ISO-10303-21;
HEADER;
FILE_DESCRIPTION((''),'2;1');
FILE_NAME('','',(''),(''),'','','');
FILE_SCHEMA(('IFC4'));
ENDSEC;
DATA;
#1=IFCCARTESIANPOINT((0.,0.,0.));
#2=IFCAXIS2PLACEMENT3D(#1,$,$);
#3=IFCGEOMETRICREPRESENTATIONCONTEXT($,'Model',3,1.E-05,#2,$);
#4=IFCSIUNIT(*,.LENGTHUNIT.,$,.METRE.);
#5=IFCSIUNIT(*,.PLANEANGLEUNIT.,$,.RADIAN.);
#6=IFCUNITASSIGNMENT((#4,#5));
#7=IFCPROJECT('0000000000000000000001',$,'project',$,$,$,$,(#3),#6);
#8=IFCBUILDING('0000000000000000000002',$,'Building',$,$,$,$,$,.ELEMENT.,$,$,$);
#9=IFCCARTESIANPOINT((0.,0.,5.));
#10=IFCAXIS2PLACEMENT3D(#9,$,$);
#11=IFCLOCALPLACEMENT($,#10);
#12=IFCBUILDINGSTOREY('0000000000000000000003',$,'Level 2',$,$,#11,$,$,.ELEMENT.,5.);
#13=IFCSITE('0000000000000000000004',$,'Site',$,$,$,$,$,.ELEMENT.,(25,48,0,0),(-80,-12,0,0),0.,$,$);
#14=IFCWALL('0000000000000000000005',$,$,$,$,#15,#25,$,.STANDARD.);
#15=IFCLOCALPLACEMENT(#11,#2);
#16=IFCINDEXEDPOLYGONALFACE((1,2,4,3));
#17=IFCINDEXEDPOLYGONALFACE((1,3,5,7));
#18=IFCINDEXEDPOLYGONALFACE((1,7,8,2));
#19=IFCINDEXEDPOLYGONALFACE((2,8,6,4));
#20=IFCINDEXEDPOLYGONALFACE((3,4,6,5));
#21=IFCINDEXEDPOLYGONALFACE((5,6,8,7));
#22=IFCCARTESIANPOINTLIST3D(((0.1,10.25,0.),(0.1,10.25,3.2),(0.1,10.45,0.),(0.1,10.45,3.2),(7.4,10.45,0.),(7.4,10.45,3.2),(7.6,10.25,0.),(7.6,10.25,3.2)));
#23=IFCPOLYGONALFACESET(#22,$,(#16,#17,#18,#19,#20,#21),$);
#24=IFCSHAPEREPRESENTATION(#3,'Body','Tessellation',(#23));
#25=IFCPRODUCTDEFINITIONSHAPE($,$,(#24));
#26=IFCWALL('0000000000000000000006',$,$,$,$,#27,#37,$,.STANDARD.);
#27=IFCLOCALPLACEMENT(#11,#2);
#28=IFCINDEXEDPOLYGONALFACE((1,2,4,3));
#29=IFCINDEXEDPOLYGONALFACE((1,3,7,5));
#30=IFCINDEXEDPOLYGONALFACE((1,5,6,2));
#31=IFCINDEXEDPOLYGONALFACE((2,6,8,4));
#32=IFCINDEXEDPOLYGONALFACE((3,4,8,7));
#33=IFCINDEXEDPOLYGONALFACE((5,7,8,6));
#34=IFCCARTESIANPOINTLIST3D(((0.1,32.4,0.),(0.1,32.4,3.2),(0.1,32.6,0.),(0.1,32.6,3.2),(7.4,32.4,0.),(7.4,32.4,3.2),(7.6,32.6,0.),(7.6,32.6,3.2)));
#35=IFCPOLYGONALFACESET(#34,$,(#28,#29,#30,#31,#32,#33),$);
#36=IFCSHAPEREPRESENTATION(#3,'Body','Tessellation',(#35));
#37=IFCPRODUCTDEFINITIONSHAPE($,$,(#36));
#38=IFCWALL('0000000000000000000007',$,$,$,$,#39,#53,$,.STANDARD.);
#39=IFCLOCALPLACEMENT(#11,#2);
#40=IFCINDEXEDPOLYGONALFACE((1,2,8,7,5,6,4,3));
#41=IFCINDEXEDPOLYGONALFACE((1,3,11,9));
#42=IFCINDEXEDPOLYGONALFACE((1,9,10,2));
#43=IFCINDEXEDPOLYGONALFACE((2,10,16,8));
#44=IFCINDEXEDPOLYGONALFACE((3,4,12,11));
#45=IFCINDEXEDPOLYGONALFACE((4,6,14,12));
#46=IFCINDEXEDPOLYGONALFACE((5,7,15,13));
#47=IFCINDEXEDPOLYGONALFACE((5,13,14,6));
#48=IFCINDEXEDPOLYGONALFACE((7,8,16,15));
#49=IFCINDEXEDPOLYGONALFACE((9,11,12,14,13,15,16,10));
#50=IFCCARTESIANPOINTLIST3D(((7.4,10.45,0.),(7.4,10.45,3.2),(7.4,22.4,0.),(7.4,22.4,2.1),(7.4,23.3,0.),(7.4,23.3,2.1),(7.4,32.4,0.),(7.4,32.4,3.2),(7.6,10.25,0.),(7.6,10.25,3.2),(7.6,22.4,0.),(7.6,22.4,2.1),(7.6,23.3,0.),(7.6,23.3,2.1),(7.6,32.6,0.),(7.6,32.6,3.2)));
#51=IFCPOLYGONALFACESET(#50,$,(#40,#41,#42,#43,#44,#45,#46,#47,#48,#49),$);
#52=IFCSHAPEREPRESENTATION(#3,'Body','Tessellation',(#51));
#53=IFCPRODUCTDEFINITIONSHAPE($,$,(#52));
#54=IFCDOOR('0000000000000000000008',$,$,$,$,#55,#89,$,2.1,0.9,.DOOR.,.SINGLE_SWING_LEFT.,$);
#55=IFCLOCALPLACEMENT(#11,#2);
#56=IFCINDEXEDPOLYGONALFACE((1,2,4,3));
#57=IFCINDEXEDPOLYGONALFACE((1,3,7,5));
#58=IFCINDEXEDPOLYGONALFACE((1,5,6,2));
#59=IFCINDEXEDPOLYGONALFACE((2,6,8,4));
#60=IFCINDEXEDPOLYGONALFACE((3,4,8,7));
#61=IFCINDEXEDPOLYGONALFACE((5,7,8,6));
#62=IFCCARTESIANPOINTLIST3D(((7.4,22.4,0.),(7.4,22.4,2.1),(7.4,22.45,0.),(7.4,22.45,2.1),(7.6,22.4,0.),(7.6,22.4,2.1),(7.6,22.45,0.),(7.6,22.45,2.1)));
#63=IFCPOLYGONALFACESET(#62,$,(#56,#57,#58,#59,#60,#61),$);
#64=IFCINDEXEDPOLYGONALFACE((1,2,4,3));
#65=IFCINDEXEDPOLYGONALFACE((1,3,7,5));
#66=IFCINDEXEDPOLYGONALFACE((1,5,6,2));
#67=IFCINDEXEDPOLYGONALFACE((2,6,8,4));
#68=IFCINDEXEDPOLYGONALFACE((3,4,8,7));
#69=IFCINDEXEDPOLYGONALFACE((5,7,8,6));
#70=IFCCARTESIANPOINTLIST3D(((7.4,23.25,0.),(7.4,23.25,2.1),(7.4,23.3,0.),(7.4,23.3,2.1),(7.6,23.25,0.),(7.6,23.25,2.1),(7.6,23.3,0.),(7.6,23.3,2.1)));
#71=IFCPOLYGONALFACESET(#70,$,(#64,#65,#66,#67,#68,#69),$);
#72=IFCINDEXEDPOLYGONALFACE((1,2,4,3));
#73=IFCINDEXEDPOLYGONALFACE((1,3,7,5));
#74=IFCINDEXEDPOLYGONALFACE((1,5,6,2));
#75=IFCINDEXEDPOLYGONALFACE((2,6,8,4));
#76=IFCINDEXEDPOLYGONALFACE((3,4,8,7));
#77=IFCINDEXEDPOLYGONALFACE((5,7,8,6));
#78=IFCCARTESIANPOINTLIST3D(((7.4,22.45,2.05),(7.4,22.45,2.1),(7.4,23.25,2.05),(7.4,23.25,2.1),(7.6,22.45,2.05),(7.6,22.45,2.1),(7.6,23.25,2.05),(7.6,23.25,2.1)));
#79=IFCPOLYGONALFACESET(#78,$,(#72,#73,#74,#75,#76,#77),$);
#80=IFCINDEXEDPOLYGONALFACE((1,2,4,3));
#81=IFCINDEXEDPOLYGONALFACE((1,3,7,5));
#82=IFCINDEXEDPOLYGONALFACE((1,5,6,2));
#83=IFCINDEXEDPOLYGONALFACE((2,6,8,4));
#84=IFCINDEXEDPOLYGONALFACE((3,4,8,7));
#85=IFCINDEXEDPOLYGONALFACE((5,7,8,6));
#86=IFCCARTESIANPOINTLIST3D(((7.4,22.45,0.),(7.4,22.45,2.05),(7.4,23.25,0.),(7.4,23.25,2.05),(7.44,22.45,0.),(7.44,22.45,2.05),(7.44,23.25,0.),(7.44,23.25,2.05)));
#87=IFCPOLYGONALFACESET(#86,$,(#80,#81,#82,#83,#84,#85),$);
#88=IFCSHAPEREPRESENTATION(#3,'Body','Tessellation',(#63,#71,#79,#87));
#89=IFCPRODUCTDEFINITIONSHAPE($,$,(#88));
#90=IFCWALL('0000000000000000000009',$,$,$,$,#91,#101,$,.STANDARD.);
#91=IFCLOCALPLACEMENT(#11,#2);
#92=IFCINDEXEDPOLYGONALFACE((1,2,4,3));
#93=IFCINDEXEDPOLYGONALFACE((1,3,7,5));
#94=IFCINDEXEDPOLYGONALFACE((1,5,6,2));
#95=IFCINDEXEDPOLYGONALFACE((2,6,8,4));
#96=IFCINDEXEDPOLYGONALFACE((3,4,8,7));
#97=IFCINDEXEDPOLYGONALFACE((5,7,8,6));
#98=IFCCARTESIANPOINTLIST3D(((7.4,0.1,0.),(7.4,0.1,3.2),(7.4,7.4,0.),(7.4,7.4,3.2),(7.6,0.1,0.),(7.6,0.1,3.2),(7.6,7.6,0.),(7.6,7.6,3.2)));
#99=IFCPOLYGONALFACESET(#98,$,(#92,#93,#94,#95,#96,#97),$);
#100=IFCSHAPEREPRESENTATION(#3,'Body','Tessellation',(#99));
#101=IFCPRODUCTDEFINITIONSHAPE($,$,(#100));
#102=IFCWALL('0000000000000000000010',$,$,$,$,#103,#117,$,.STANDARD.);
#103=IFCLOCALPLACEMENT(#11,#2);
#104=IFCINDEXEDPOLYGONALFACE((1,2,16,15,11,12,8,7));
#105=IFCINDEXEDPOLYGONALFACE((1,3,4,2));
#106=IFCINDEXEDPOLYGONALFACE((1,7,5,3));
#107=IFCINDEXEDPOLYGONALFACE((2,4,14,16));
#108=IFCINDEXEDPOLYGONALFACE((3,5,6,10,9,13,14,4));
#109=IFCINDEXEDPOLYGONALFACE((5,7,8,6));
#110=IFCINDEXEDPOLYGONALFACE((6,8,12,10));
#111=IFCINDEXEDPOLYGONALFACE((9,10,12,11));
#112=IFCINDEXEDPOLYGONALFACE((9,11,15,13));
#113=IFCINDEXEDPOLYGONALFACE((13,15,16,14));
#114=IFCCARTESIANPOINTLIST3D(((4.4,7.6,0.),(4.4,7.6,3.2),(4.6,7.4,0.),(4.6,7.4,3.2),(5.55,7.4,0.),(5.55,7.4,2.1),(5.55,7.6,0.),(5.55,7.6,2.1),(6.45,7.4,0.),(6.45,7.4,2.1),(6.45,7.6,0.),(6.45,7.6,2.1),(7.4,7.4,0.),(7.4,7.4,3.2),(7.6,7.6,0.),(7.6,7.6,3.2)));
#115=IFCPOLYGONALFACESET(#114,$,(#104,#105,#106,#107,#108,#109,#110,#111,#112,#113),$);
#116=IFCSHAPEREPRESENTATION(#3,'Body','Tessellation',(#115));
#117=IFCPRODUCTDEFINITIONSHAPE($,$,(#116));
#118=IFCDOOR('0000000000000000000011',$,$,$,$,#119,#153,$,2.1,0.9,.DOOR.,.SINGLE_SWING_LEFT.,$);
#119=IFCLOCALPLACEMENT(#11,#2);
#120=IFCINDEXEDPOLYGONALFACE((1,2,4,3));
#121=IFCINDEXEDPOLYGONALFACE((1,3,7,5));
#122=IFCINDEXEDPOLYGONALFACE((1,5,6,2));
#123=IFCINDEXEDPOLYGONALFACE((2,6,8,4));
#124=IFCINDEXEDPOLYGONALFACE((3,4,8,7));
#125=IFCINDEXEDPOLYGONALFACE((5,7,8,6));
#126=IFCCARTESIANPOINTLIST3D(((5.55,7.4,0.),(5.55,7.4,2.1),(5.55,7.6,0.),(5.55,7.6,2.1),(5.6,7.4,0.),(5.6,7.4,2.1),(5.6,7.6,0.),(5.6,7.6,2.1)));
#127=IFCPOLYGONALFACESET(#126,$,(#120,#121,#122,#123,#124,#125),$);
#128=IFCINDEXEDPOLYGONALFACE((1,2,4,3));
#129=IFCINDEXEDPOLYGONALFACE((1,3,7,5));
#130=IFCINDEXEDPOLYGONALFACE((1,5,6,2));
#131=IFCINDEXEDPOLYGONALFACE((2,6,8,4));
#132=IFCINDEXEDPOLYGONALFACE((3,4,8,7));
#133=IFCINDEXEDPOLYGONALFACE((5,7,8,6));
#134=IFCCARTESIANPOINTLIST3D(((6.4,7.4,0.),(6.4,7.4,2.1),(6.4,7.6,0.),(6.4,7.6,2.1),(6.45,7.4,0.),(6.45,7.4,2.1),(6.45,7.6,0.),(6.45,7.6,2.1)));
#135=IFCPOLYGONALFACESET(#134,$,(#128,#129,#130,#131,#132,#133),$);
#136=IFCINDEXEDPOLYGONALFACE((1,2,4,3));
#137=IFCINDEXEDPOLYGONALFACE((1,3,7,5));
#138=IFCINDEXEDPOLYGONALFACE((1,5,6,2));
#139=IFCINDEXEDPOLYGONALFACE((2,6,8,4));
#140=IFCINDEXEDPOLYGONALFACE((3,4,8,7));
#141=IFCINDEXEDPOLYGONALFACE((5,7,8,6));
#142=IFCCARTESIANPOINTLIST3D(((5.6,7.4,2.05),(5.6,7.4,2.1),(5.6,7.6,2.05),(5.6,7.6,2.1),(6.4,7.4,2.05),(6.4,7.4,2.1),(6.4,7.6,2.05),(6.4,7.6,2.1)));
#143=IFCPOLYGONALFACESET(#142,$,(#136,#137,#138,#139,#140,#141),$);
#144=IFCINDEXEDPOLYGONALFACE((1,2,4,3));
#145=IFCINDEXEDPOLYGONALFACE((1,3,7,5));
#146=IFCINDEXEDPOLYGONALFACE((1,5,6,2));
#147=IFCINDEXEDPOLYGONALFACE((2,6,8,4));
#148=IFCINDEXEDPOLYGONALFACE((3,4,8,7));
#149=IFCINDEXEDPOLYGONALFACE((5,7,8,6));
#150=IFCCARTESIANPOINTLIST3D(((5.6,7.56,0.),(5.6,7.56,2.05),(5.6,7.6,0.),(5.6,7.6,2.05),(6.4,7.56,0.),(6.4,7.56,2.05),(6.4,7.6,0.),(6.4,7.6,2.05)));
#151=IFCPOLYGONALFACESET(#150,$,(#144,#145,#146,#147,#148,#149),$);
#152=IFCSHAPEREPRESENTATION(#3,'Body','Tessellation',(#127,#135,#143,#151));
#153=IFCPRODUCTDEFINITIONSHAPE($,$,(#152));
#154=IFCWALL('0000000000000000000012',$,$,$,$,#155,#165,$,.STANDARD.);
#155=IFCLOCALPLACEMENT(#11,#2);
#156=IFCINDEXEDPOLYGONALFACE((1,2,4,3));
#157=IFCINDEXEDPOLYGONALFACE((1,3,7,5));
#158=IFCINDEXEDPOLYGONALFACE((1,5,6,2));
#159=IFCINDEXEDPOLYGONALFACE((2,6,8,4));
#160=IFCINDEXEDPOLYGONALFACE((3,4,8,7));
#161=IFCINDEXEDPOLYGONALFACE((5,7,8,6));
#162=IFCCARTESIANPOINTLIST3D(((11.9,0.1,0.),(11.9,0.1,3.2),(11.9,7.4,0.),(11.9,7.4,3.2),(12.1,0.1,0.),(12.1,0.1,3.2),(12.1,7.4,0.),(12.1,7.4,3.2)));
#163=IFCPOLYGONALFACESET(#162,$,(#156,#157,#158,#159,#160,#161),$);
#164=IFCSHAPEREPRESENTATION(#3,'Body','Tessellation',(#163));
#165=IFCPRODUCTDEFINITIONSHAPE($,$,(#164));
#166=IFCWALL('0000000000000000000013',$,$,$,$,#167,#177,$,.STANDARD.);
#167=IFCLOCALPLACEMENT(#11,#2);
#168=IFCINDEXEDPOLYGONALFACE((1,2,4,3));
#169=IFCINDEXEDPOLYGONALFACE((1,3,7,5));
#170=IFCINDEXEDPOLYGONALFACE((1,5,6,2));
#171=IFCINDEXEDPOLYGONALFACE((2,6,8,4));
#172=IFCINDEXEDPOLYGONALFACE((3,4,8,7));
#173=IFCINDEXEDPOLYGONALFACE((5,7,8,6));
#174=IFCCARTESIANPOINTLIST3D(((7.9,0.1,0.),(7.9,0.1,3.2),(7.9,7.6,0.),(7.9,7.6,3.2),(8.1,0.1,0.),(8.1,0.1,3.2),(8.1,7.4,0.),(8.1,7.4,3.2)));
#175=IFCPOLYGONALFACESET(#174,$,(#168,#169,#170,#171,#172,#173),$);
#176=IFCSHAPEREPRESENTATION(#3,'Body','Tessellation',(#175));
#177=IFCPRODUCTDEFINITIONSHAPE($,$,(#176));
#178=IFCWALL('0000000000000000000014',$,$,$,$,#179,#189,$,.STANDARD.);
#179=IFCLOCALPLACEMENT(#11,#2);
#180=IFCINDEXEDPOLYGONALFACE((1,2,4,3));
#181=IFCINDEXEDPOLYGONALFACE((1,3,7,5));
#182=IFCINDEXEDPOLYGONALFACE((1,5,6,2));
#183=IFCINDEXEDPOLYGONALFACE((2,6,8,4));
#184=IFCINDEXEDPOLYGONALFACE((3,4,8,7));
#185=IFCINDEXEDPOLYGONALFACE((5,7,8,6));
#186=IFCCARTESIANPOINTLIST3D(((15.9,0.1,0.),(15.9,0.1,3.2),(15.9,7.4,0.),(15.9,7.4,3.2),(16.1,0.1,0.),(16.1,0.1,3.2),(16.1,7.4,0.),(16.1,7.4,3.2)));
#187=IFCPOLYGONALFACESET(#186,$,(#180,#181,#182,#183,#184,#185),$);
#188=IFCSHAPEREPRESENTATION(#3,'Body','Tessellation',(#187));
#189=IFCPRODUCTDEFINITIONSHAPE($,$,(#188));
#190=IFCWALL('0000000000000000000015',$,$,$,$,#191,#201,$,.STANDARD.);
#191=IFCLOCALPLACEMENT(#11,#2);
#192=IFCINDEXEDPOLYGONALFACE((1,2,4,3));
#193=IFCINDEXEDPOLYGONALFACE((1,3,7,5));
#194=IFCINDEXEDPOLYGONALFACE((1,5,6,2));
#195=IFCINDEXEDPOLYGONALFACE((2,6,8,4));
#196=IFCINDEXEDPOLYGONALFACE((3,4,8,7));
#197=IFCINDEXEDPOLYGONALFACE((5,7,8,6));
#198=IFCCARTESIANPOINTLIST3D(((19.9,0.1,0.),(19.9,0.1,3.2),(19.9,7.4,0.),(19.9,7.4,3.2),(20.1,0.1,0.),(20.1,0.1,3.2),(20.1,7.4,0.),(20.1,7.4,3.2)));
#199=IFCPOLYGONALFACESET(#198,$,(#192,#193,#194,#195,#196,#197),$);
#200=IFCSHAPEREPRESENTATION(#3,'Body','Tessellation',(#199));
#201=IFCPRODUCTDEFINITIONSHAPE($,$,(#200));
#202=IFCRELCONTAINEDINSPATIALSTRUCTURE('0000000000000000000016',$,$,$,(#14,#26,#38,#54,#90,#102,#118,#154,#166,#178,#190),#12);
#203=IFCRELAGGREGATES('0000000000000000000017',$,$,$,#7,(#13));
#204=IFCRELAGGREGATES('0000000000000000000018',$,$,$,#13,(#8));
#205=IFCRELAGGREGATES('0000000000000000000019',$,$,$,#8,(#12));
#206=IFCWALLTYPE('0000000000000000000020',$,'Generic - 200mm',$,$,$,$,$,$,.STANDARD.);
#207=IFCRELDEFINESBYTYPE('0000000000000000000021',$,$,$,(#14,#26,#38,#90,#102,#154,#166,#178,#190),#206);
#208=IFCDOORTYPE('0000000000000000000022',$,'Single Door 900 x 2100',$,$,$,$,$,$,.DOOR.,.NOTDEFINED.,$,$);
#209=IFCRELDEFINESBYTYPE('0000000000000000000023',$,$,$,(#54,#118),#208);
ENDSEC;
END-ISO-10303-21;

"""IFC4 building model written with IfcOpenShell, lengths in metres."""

from ifc_helpers import new_model, si_unit, frame, frame_2d, origin, origin_with_axes, origin_2d, place, context, project, spatial, polyline, rectangle, outline, extrude, type_object, element, fill, save


model = new_model("IFC4")

# Units and contexts
model_context = context("Model", 3, precision=1e-05, world=origin())
ifc_project = project(units=[si_unit("LENGTHUNIT", "METRE"), si_unit("PLANEANGLEUNIT", "RADIAN")], contexts=[model_context])

# Site, building, storey
site = spatial("IfcSite", under=ifc_project, Name="Site", CompositionType="ELEMENT", RefLatitude=(25, 48, 0, 0), RefLongitude=(-80, -12, 0, 0), RefElevation=0.0)
building = spatial("IfcBuilding", under=site, Name="Building", CompositionType="ELEMENT")
storey_placement = place(None, frame((0.0, 0.0, 5.0)))
storey = spatial("IfcBuildingStorey", under=building, at=storey_placement, Name="Level 2", CompositionType="ELEMENT", Elevation=5.0)

# Shared definitions
wall_type = type_object("IfcWallType", Name="Generic - 200mm", PredefinedType="STANDARD")

# Walls
wall_1_placement = place(None, frame((0.0, 10.35, 5.0), z_axis=(0.0, 0.0, 1.0), x_axis=(1.0, 0.0, 0.0)))
element("IfcWall", 1, at=wall_1_placement, inside=storey, type_object=wall_type, PredefinedType="STANDARD", context=model_context, shape_type="SweptSolid", body=[
    extrude(outline(polyline([(0.1, -0.1), (7.6, -0.1), (7.4, 0.1), (0.1, 0.1), (0.1, -0.1)])), origin(), (0.0, 0.0, 1.0), 3.2),
])
wall_2_placement = place(None, frame((0.0, 32.5, 5.0), z_axis=(0.0, 0.0, 1.0), x_axis=(1.0, 0.0, 0.0)))
element("IfcWall", 2, at=wall_2_placement, inside=storey, type_object=wall_type, PredefinedType="STANDARD", context=model_context, shape_type="SweptSolid", body=[
    extrude(outline(polyline([(0.1, -0.1), (7.4, -0.1), (7.6, 0.1), (0.1, 0.1), (0.1, -0.1)])), origin(), (0.0, 0.0, 1.0), 3.2),
])

# Wall, opening, door
wall_3_placement = place(None, frame((7.5, 10.35, 5.0), z_axis=(0.0, 0.0, 1.0), x_axis=(0.0, 1.0, 0.0)))
wall_3 = element("IfcWall", 3, at=wall_3_placement, inside=storey, type_object=wall_type, PredefinedType="STANDARD", context=model_context, shape_type="SweptSolid", body=[
    extrude(outline(polyline([(-0.1, -0.1), (22.25, -0.1), (22.05, 0.1), (0.1, 0.1), (-0.1, -0.1)])), origin(), (0.0, 0.0, 1.0), 3.2),
])
opening_1_placement = place(wall_3_placement, frame((12.5, 0.0, 0.0), z_axis=(0.0, 0.0, 1.0), x_axis=(1.0, 0.0, 0.0)))
opening_1 = element("IfcOpeningElement", 4, at=opening_1_placement, cuts=wall_3, PredefinedType="OPENING", context=model_context, shape_type="SweptSolid", body=[
    extrude(rectangle(XDim=0.9, YDim=0.202, at=origin_2d()), origin(), (0.0, 0.0, 1.0), 2.1),
])
door_type = type_object("IfcDoorType", Name="Single Door 900 x 2100", OperationType="NOTDEFINED", PredefinedType="DOOR")
door_1_placement = place(opening_1_placement, origin_with_axes())
door_1 = element("IfcDoor", 5, at=door_1_placement, inside=storey, type_object=door_type, OperationType="SINGLE_SWING_LEFT", OverallHeight=2.1, OverallWidth=0.9, PredefinedType="DOOR", context=model_context, shape_type="SweptSolid", body=[
    extrude(rectangle(XDim=0.05, YDim=0.2, at=frame_2d((-0.425, 0.0))), origin(), (0.0, 0.0, 1.0), 2.1),
    extrude(rectangle(XDim=0.05, YDim=0.2, at=frame_2d((0.425, 0.0))), origin(), (0.0, 0.0, 1.0), 2.1),
    extrude(rectangle(XDim=0.8, YDim=0.2, at=origin_2d()), frame((0.0, 0.0, 2.05)), (0.0, 0.0, 1.0), 0.05),
    extrude(rectangle(XDim=0.8, YDim=0.04, at=frame_2d((0.0, 0.08))), origin(), (0.0, 0.0, 1.0), 2.05),
])
fill(opening_1, door_1)

# Wall
wall_4_placement = place(None, frame((7.5, 7.5, 5.0), z_axis=(0.0, 0.0, 1.0), x_axis=(0.0, -1.0, 0.0)))
element("IfcWall", 6, at=wall_4_placement, inside=storey, type_object=wall_type, PredefinedType="STANDARD", context=model_context, shape_type="SweptSolid", body=[
    extrude(outline(polyline([(0.1, -0.1), (7.4, -0.1), (7.4, 0.1), (-0.1, 0.1), (0.1, -0.1)])), origin(), (0.0, 0.0, 1.0), 3.2),
])

# Wall, opening, door
wall_5_placement = place(None, frame((4.5, 7.5, 5.0), z_axis=(0.0, 0.0, 1.0), x_axis=(1.0, 0.0, 0.0)))
wall_5 = element("IfcWall", 7, at=wall_5_placement, inside=storey, type_object=wall_type, PredefinedType="STANDARD", context=model_context, shape_type="SweptSolid", body=[
    extrude(outline(polyline([(0.1, -0.1), (2.9, -0.1), (3.1, 0.1), (-0.1, 0.1), (0.1, -0.1)])), origin(), (0.0, 0.0, 1.0), 3.2),
])
opening_2_placement = place(wall_5_placement, frame((1.5, 0.0, 0.0), z_axis=(0.0, 0.0, 1.0), x_axis=(1.0, 0.0, 0.0)))
opening_2 = element("IfcOpeningElement", 8, at=opening_2_placement, cuts=wall_5, PredefinedType="OPENING", context=model_context, shape_type="SweptSolid", body=[
    extrude(rectangle(XDim=0.9, YDim=0.202, at=origin_2d()), origin(), (0.0, 0.0, 1.0), 2.1),
])
door_2_placement = place(opening_2_placement, origin_with_axes())
door_2 = element("IfcDoor", 9, at=door_2_placement, inside=storey, type_object=door_type, OperationType="SINGLE_SWING_LEFT", OverallHeight=2.1, OverallWidth=0.9, PredefinedType="DOOR", context=model_context, shape_type="SweptSolid", body=[
    extrude(rectangle(XDim=0.05, YDim=0.2, at=frame_2d((-0.425, 0.0))), origin(), (0.0, 0.0, 1.0), 2.1),
    extrude(rectangle(XDim=0.05, YDim=0.2, at=frame_2d((0.425, 0.0))), origin(), (0.0, 0.0, 1.0), 2.1),
    extrude(rectangle(XDim=0.8, YDim=0.2, at=origin_2d()), frame((0.0, 0.0, 2.05)), (0.0, 0.0, 1.0), 0.05),
    extrude(rectangle(XDim=0.8, YDim=0.04, at=frame_2d((0.0, 0.08))), origin(), (0.0, 0.0, 1.0), 2.05),
])
fill(opening_2, door_2)

# Walls
wall_6_placement = place(None, frame((12.0, 7.5, 5.0), z_axis=(0.0, 0.0, 1.0), x_axis=(0.0, -1.0, 0.0)))
element("IfcWall", 10, at=wall_6_placement, inside=storey, type_object=wall_type, PredefinedType="STANDARD", context=model_context, shape_type="SweptSolid", body=[
    extrude(outline(polyline([(0.1, -0.1), (7.4, -0.1), (7.4, 0.1), (0.1, 0.1), (0.1, -0.1)])), origin(), (0.0, 0.0, 1.0), 3.2),
])
wall_7_placement = place(None, frame((8.0, 7.5, 5.0), z_axis=(0.0, 0.0, 1.0), x_axis=(0.0, -1.0, 0.0)))
element("IfcWall", 11, at=wall_7_placement, inside=storey, type_object=wall_type, PredefinedType="STANDARD", context=model_context, shape_type="SweptSolid", body=[
    extrude(outline(polyline([(-0.1, -0.1), (7.4, -0.1), (7.4, 0.1), (0.1, 0.1), (-0.1, -0.1)])), origin(), (0.0, 0.0, 1.0), 3.2),
])
wall_8_placement = place(None, frame((16.0, 7.5, 5.0), z_axis=(0.0, 0.0, 1.0), x_axis=(0.0, -1.0, 0.0)))
element("IfcWall", 12, at=wall_8_placement, inside=storey, type_object=wall_type, PredefinedType="STANDARD", context=model_context, shape_type="SweptSolid", body=[
    extrude(outline(polyline([(0.1, -0.1), (7.4, -0.1), (7.4, 0.1), (0.1, 0.1), (0.1, -0.1)])), origin(), (0.0, 0.0, 1.0), 3.2),
])
wall_9_placement = place(None, frame((20.0, 7.5, 5.0), z_axis=(0.0, 0.0, 1.0), x_axis=(0.0, -1.0, 0.0)))
element("IfcWall", 13, at=wall_9_placement, inside=storey, type_object=wall_type, PredefinedType="STANDARD", context=model_context, shape_type="SweptSolid", body=[
    extrude(outline(polyline([(0.1, -0.1), (7.4, -0.1), (7.4, 0.1), (0.1, 0.1), (0.1, -0.1)])), origin(), (0.0, 0.0, 1.0), 3.2),
])

save(model, "model.ifc")
